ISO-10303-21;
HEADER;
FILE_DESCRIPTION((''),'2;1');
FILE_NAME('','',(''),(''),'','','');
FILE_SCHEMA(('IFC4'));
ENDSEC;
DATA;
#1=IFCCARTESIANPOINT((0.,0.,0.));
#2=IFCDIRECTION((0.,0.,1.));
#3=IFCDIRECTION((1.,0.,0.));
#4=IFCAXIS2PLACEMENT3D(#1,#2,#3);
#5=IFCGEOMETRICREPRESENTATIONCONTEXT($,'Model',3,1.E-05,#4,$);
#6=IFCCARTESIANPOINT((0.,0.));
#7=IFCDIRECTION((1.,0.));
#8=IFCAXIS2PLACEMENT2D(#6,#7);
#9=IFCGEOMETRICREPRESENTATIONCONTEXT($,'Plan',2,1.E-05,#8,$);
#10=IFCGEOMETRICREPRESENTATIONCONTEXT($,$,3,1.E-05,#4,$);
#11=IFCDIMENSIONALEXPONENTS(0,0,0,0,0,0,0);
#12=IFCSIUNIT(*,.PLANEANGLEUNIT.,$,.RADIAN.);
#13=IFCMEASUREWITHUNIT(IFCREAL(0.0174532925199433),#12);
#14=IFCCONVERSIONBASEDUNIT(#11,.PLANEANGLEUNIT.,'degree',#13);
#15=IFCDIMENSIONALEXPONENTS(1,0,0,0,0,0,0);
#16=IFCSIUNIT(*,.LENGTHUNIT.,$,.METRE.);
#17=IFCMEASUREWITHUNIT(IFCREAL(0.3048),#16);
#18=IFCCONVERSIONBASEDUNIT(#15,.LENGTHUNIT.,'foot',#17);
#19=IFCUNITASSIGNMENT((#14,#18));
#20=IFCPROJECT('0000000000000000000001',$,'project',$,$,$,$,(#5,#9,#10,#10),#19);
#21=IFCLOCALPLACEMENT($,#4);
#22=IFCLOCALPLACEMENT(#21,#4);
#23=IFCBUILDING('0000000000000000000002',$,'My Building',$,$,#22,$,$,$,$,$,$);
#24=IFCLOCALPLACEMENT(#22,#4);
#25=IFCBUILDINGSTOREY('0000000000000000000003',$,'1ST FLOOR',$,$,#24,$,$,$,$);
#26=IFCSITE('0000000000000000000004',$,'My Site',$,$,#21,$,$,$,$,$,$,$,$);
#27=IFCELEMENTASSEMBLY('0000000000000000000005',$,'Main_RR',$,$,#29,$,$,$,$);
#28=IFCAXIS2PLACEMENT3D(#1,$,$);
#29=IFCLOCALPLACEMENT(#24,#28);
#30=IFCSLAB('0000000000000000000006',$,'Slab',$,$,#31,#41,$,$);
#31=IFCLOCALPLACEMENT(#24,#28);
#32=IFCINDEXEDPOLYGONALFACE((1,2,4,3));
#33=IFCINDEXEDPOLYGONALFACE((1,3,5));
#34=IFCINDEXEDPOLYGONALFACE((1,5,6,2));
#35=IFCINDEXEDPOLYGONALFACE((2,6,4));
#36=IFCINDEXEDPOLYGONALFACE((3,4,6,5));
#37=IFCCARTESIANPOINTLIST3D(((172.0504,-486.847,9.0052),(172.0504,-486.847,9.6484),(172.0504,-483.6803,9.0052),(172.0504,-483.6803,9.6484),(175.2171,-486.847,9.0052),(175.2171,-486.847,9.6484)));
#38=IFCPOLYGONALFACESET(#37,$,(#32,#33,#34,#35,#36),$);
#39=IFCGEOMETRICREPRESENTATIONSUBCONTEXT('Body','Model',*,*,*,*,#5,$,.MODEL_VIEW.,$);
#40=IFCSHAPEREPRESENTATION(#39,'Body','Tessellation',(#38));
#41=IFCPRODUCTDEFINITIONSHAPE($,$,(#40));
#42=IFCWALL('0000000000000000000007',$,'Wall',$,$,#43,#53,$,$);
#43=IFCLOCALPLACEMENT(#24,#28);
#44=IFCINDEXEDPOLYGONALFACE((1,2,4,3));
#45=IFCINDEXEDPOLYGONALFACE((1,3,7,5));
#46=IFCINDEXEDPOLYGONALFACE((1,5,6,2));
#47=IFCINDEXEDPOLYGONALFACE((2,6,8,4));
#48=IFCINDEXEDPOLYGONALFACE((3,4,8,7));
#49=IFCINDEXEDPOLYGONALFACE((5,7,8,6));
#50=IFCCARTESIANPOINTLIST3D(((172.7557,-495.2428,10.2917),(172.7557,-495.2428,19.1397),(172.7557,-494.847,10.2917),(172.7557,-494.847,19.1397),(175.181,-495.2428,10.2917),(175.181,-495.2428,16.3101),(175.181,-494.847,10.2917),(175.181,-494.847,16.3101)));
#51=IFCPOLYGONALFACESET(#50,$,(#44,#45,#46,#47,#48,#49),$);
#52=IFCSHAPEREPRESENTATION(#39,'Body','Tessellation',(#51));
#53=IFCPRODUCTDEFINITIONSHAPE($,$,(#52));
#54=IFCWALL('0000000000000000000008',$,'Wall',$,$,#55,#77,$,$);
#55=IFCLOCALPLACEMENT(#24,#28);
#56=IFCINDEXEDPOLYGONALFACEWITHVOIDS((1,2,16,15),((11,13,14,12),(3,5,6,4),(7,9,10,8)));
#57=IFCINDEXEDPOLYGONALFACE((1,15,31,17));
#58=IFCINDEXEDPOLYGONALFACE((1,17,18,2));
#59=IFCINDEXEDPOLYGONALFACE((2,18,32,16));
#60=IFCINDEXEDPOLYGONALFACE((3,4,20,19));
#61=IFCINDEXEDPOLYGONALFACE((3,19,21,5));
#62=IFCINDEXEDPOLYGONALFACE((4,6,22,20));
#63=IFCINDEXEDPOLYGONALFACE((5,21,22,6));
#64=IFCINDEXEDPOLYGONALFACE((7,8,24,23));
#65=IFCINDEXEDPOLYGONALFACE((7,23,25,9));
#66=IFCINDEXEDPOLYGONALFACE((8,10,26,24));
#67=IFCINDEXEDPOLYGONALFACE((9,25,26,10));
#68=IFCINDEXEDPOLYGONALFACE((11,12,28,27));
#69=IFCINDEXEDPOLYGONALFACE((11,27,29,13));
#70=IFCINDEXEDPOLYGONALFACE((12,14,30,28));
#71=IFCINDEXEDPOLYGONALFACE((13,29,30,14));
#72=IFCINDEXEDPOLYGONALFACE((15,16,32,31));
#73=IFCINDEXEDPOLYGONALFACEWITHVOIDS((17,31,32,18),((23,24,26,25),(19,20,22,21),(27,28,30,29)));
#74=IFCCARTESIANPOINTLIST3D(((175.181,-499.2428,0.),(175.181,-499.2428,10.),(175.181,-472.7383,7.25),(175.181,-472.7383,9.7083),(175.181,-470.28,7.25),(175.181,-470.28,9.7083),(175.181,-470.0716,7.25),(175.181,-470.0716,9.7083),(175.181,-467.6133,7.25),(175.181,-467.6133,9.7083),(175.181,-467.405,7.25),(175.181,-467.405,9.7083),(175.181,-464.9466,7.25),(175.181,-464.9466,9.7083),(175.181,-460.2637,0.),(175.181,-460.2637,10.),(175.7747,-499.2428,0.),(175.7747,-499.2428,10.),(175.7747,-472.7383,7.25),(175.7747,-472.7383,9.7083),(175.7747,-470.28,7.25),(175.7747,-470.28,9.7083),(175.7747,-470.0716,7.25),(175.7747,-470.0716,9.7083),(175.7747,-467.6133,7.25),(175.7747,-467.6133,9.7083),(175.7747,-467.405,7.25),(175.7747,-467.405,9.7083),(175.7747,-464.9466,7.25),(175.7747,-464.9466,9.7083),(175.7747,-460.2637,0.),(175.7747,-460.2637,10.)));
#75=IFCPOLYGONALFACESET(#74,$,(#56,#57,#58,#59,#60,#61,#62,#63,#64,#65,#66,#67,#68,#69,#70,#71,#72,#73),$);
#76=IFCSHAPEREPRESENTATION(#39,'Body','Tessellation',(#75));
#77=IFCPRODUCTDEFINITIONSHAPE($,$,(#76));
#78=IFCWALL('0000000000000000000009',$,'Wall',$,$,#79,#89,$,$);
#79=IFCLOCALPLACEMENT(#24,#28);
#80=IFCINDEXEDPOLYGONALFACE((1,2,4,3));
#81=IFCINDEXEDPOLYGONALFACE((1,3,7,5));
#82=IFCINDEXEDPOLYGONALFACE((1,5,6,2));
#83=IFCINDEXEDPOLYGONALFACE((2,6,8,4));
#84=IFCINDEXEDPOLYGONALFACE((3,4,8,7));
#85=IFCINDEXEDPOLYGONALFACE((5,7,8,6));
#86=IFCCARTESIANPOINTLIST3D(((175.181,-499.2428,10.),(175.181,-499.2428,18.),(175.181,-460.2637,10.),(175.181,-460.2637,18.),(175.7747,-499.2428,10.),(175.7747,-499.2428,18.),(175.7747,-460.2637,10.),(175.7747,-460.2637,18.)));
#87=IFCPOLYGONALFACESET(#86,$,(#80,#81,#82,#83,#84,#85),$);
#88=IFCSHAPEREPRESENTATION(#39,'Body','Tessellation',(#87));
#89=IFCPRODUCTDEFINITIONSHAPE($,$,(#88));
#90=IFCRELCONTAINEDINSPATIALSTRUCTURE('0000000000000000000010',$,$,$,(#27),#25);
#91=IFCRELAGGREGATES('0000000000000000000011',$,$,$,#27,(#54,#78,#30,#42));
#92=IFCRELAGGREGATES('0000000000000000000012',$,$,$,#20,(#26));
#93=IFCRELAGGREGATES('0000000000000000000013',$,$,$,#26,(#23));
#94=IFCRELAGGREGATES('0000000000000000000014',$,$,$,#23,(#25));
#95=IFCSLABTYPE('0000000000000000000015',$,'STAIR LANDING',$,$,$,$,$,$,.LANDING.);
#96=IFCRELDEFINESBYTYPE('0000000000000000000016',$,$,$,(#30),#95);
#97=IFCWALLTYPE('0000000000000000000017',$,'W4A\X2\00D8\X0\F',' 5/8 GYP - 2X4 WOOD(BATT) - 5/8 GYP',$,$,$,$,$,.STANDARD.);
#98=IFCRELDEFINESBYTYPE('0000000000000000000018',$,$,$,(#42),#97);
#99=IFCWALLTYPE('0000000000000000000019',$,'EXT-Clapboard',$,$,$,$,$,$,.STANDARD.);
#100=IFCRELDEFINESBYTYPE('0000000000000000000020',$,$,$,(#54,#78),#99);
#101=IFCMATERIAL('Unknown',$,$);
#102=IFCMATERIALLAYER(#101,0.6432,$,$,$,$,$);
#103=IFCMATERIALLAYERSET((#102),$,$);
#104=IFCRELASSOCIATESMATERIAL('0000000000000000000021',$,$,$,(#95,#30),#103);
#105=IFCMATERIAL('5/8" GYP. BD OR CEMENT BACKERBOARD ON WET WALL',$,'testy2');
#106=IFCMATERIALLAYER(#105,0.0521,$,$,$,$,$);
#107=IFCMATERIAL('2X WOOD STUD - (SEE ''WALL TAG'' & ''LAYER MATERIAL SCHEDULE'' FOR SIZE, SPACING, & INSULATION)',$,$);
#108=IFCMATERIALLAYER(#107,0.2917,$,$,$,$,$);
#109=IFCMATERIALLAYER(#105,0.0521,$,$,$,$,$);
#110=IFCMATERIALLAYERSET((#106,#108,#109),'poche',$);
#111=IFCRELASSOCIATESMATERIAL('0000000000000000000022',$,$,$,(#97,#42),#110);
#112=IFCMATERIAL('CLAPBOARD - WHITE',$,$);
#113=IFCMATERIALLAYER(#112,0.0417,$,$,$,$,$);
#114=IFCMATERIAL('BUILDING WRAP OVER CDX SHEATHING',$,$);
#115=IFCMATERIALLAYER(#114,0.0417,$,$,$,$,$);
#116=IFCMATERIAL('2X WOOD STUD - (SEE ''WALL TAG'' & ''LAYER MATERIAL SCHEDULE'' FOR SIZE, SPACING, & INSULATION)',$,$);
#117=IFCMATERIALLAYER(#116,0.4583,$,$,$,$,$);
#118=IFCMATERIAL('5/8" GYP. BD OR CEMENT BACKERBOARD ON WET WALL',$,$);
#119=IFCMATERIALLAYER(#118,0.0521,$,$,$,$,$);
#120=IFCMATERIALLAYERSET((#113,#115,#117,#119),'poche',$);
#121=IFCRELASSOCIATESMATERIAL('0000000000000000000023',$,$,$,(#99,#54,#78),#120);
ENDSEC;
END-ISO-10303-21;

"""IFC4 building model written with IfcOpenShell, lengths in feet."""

from ifc_helpers import new_model, entity, si_unit, converted_unit, frame, origin_with_axes, origin_2d_with_axis, place, context, subcontext, project, spatial, line, indexed_curve, outline, extrude, clip, halfspace, source, transform, mapped, material, layer, layer_set, layer_usage, type_object, element, aggregate, save


model = new_model("IFC4")

# Units and contexts
model_context = context("Model", 3, precision=1e-05, world=origin_with_axes())
plan_context = context("Plan", 2, precision=1e-05, world=origin_2d_with_axis())
context_of_model = context(None, 3, precision=1e-05, world=origin_with_axes())
body_context = subcontext(model_context, "Body", "Model", "MODEL_VIEW")
ifc_project = project(units=[converted_unit("PLANEANGLEUNIT", "degree", entity("IfcReal", 0.0174532925199433), si_unit("PLANEANGLEUNIT", "RADIAN"), dimensions=[0, 0, 0, 0, 0, 0, 0]), converted_unit("LENGTHUNIT", "foot", entity("IfcReal", 0.3048), si_unit("LENGTHUNIT", "METRE"), dimensions=[1, 0, 0, 0, 0, 0, 0])], contexts=[model_context, plan_context, context_of_model, context_of_model])

# Site, building, storey
site_placement = place(None, origin_with_axes())
site = spatial("IfcSite", under=ifc_project, at=site_placement, Name="My Site")
building_placement = place(site_placement, origin_with_axes())
building = spatial("IfcBuilding", under=site, at=building_placement, Name="My Building")
storey_placement = place(building_placement, origin_with_axes())
storey = spatial("IfcBuildingStorey", under=building, at=storey_placement, Name="1ST FLOOR")

# Element assembly, slab, walls, openings
assembly_placement = place(storey_placement, origin_with_axes())
assembly = element("IfcElementAssembly", 1, at=assembly_placement, inside=storey, Name="Main_RR")
ifc_material_1 = material(Name="Unknown")
ifc_layer_1 = layer(ifc_material_1, 0.6432)
ifc_layer_set_1 = layer_set([ifc_layer_1])
slab_type = type_object("IfcSlabType", Name="STAIR LANDING", PredefinedType="LANDING", material=ifc_layer_set_1)
ifc_layer_usage_1 = layer_usage(ifc_layer_set_1, "AXIS3", "POSITIVE", 0.0)
slab_1_placement = place(assembly_placement, frame((172.0504, -486.847, 9.0052), z_axis=(0.0, 0.0, 1.0), x_axis=(1.0, 0.0, 0.0)))
slab_1 = element("IfcSlab", 2, at=slab_1_placement, type_object=slab_type, material=ifc_layer_usage_1, Name="Slab", context=body_context, shape_type="SweptSolid", body=[
    extrude(outline(indexed_curve([(0.0, 3.1667), (3.1667, 0.0), (0.0, 0.0)], segments=[line(3, 1), line(1, 2), line(2, 3)], self_intersect=False)), None, (0.0, 0.0, 1.0), 0.6432),
])
ifc_material_2 = material(Name="5/8\" GYP. BD OR CEMENT BACKERBOARD ON WET WALL", Category="testy2")
ifc_layer_2 = layer(ifc_material_2, 0.0521)
ifc_material_3 = material(Name="2X WOOD STUD - (SEE 'WALL TAG' & 'LAYER MATERIAL SCHEDULE' FOR SIZE, SPACING, & INSULATION)")
ifc_layer_3 = layer(ifc_material_3, 0.2917)
ifc_layer_4 = layer(ifc_material_2, 0.0521)
ifc_layer_set_2 = layer_set([ifc_layer_2, ifc_layer_3, ifc_layer_4], Name="poche")
ifc_layer_usage_2 = layer_usage(ifc_layer_set_2, "AXIS2", "POSITIVE", 0.0)
wall_type_1 = type_object("IfcWallType", Name="W4AØF", Description=" 5/8 GYP - 2X4 WOOD(BATT) - 5/8 GYP", PredefinedType="STANDARD", material=ifc_layer_set_2)
wall_1_placement = place(assembly_placement, frame((172.7557, -495.2428, 10.2917), z_axis=(0.0, 0.0, 1.0), x_axis=(1.0, 0.0, 0.0)))
wall_1 = element("IfcWall", 3, at=wall_1_placement, type_object=wall_type_1, material=ifc_layer_usage_2, Name="Wall", context=body_context, shape_type="Clipping", body=[
    clip(extrude(outline(indexed_curve([(0.0, 0.0), (0.0, 0.3958), (2.4253, 0.3958), (2.4253, 0.0), (0.0, 0.0)], self_intersect=False)), origin_with_axes(), (0.0, 0.0, 1.0), 19.1397), halfspace(frame((0.0, 0.0, 8.8481), z_axis=(0.759271, 0.0, 0.650774), x_axis=(0.0, -1.0, 0.0)), False)),
])
ifc_material_4 = material(Name="CLAPBOARD - WHITE")
ifc_layer_5 = layer(ifc_material_4, 0.0417)
ifc_material_5 = material(Name="BUILDING WRAP OVER CDX SHEATHING")
ifc_layer_6 = layer(ifc_material_5, 0.0417)
ifc_material_6 = material(Name="2X WOOD STUD - (SEE 'WALL TAG' & 'LAYER MATERIAL SCHEDULE' FOR SIZE, SPACING, & INSULATION)")
ifc_layer_7 = layer(ifc_material_6, 0.4583)
ifc_material_7 = material(Name="5/8\" GYP. BD OR CEMENT BACKERBOARD ON WET WALL")
ifc_layer_8 = layer(ifc_material_7, 0.0521)
ifc_layer_set_3 = layer_set([ifc_layer_5, ifc_layer_6, ifc_layer_7, ifc_layer_8], Name="poche")
ifc_layer_usage_3 = layer_usage(ifc_layer_set_3, "AXIS2", "POSITIVE", 0.0)
wall_type_2 = type_object("IfcWallType", Name="EXT-Clapboard", PredefinedType="STANDARD", material=ifc_layer_set_3)
wall_2_placement = place(assembly_placement, frame((175.7747, -499.2428, 0.0), z_axis=(0.0, 0.0, 1.0), x_axis=(0.0, 1.0, 0.0)))
wall_2 = element("IfcWall", 4, at=wall_2_placement, type_object=wall_type_2, material=ifc_layer_usage_3, Name="Wall", context=body_context, shape_type="SweptSolid", body=[
    extrude(outline(indexed_curve([(0.0, 0.0), (0.0, 0.5938), (38.9791, 0.5938), (38.9791, 0.0), (0.0, 0.0)], self_intersect=False)), origin_with_axes(), (0.0, 0.0, 1.0), 10.0),
])
shared_shape = source(origin_with_axes(), body_context, "Body", "SweptSolid", [
    extrude(outline(indexed_curve([(0.0, 0.0), (2.4583, 0.0), (2.4583, 2.4583), (0.0, 2.4583)], segments=[line(1, 2, 3, 4, 1)])), frame((0.0, -1.9685, 0.0), z_axis=(0.0, -1.0, 0.0), x_axis=(1.0, 0.0, 0.0)), (0.0, 0.0, -1.0), 3.937),
])
opening_1_placement = place(wall_2_placement, frame((29.1712, 0.0, 7.25), z_axis=(0.0, 0.0, 1.0), x_axis=(1.0, 0.0, 0.0)))
element("IfcOpeningElement", 5, at=opening_1_placement, cuts=wall_2, PredefinedType="OPENING", context=body_context, shape_type="MappedRepresentation", body=[
    mapped(shared_shape, transform((0.0, 0.0, 0.0), x_axis=(1.0, 0.0, 0.0), y_axis=(0.0, 1.0, 0.0), z_axis=(0.0, 0.0, 1.0), scale=1.0)),
])
opening_2_placement = place(wall_2_placement, frame((26.5045, 0.0, 7.25), z_axis=(0.0, 0.0, 1.0), x_axis=(1.0, 0.0, 0.0)))
element("IfcOpeningElement", 6, at=opening_2_placement, cuts=wall_2, PredefinedType="OPENING", context=body_context, shape_type="MappedRepresentation", body=[
    mapped(shared_shape, transform((0.0, 0.0, 0.0), x_axis=(1.0, 0.0, 0.0), y_axis=(0.0, 1.0, 0.0), z_axis=(0.0, 0.0, 1.0), scale=1.0)),
])
opening_3_placement = place(wall_2_placement, frame((31.8378, 0.0, 7.25), z_axis=(0.0, 0.0, 1.0), x_axis=(1.0, 0.0, 0.0)))
element("IfcOpeningElement", 7, at=opening_3_placement, cuts=wall_2, PredefinedType="OPENING", context=body_context, shape_type="MappedRepresentation", body=[
    mapped(shared_shape, transform((0.0, 0.0, 0.0), x_axis=(1.0, 0.0, 0.0), y_axis=(0.0, 1.0, 0.0), z_axis=(0.0, 0.0, 1.0), scale=1.0)),
])
ifc_layer_usage_4 = layer_usage(ifc_layer_set_3, "AXIS2", "POSITIVE", 0.0)
wall_3_placement = place(assembly_placement, frame((175.7747, -499.2428, 10.0), z_axis=(0.0, 0.0, 1.0), x_axis=(0.0, 1.0, 0.0)))
wall_3 = element("IfcWall", 8, at=wall_3_placement, type_object=wall_type_2, material=ifc_layer_usage_4, Name="Wall", context=body_context, shape_type="SweptSolid", body=[
    extrude(outline(indexed_curve([(0.0, 0.0), (0.0, 0.5938), (38.9791, 0.5938), (38.9791, 0.0), (0.0, 0.0)], self_intersect=False)), origin_with_axes(), (0.0, 0.0, 1.0), 8.0),
])
aggregate(assembly, [wall_2, wall_3, slab_1, wall_1])

save(model, "model.ifc")
